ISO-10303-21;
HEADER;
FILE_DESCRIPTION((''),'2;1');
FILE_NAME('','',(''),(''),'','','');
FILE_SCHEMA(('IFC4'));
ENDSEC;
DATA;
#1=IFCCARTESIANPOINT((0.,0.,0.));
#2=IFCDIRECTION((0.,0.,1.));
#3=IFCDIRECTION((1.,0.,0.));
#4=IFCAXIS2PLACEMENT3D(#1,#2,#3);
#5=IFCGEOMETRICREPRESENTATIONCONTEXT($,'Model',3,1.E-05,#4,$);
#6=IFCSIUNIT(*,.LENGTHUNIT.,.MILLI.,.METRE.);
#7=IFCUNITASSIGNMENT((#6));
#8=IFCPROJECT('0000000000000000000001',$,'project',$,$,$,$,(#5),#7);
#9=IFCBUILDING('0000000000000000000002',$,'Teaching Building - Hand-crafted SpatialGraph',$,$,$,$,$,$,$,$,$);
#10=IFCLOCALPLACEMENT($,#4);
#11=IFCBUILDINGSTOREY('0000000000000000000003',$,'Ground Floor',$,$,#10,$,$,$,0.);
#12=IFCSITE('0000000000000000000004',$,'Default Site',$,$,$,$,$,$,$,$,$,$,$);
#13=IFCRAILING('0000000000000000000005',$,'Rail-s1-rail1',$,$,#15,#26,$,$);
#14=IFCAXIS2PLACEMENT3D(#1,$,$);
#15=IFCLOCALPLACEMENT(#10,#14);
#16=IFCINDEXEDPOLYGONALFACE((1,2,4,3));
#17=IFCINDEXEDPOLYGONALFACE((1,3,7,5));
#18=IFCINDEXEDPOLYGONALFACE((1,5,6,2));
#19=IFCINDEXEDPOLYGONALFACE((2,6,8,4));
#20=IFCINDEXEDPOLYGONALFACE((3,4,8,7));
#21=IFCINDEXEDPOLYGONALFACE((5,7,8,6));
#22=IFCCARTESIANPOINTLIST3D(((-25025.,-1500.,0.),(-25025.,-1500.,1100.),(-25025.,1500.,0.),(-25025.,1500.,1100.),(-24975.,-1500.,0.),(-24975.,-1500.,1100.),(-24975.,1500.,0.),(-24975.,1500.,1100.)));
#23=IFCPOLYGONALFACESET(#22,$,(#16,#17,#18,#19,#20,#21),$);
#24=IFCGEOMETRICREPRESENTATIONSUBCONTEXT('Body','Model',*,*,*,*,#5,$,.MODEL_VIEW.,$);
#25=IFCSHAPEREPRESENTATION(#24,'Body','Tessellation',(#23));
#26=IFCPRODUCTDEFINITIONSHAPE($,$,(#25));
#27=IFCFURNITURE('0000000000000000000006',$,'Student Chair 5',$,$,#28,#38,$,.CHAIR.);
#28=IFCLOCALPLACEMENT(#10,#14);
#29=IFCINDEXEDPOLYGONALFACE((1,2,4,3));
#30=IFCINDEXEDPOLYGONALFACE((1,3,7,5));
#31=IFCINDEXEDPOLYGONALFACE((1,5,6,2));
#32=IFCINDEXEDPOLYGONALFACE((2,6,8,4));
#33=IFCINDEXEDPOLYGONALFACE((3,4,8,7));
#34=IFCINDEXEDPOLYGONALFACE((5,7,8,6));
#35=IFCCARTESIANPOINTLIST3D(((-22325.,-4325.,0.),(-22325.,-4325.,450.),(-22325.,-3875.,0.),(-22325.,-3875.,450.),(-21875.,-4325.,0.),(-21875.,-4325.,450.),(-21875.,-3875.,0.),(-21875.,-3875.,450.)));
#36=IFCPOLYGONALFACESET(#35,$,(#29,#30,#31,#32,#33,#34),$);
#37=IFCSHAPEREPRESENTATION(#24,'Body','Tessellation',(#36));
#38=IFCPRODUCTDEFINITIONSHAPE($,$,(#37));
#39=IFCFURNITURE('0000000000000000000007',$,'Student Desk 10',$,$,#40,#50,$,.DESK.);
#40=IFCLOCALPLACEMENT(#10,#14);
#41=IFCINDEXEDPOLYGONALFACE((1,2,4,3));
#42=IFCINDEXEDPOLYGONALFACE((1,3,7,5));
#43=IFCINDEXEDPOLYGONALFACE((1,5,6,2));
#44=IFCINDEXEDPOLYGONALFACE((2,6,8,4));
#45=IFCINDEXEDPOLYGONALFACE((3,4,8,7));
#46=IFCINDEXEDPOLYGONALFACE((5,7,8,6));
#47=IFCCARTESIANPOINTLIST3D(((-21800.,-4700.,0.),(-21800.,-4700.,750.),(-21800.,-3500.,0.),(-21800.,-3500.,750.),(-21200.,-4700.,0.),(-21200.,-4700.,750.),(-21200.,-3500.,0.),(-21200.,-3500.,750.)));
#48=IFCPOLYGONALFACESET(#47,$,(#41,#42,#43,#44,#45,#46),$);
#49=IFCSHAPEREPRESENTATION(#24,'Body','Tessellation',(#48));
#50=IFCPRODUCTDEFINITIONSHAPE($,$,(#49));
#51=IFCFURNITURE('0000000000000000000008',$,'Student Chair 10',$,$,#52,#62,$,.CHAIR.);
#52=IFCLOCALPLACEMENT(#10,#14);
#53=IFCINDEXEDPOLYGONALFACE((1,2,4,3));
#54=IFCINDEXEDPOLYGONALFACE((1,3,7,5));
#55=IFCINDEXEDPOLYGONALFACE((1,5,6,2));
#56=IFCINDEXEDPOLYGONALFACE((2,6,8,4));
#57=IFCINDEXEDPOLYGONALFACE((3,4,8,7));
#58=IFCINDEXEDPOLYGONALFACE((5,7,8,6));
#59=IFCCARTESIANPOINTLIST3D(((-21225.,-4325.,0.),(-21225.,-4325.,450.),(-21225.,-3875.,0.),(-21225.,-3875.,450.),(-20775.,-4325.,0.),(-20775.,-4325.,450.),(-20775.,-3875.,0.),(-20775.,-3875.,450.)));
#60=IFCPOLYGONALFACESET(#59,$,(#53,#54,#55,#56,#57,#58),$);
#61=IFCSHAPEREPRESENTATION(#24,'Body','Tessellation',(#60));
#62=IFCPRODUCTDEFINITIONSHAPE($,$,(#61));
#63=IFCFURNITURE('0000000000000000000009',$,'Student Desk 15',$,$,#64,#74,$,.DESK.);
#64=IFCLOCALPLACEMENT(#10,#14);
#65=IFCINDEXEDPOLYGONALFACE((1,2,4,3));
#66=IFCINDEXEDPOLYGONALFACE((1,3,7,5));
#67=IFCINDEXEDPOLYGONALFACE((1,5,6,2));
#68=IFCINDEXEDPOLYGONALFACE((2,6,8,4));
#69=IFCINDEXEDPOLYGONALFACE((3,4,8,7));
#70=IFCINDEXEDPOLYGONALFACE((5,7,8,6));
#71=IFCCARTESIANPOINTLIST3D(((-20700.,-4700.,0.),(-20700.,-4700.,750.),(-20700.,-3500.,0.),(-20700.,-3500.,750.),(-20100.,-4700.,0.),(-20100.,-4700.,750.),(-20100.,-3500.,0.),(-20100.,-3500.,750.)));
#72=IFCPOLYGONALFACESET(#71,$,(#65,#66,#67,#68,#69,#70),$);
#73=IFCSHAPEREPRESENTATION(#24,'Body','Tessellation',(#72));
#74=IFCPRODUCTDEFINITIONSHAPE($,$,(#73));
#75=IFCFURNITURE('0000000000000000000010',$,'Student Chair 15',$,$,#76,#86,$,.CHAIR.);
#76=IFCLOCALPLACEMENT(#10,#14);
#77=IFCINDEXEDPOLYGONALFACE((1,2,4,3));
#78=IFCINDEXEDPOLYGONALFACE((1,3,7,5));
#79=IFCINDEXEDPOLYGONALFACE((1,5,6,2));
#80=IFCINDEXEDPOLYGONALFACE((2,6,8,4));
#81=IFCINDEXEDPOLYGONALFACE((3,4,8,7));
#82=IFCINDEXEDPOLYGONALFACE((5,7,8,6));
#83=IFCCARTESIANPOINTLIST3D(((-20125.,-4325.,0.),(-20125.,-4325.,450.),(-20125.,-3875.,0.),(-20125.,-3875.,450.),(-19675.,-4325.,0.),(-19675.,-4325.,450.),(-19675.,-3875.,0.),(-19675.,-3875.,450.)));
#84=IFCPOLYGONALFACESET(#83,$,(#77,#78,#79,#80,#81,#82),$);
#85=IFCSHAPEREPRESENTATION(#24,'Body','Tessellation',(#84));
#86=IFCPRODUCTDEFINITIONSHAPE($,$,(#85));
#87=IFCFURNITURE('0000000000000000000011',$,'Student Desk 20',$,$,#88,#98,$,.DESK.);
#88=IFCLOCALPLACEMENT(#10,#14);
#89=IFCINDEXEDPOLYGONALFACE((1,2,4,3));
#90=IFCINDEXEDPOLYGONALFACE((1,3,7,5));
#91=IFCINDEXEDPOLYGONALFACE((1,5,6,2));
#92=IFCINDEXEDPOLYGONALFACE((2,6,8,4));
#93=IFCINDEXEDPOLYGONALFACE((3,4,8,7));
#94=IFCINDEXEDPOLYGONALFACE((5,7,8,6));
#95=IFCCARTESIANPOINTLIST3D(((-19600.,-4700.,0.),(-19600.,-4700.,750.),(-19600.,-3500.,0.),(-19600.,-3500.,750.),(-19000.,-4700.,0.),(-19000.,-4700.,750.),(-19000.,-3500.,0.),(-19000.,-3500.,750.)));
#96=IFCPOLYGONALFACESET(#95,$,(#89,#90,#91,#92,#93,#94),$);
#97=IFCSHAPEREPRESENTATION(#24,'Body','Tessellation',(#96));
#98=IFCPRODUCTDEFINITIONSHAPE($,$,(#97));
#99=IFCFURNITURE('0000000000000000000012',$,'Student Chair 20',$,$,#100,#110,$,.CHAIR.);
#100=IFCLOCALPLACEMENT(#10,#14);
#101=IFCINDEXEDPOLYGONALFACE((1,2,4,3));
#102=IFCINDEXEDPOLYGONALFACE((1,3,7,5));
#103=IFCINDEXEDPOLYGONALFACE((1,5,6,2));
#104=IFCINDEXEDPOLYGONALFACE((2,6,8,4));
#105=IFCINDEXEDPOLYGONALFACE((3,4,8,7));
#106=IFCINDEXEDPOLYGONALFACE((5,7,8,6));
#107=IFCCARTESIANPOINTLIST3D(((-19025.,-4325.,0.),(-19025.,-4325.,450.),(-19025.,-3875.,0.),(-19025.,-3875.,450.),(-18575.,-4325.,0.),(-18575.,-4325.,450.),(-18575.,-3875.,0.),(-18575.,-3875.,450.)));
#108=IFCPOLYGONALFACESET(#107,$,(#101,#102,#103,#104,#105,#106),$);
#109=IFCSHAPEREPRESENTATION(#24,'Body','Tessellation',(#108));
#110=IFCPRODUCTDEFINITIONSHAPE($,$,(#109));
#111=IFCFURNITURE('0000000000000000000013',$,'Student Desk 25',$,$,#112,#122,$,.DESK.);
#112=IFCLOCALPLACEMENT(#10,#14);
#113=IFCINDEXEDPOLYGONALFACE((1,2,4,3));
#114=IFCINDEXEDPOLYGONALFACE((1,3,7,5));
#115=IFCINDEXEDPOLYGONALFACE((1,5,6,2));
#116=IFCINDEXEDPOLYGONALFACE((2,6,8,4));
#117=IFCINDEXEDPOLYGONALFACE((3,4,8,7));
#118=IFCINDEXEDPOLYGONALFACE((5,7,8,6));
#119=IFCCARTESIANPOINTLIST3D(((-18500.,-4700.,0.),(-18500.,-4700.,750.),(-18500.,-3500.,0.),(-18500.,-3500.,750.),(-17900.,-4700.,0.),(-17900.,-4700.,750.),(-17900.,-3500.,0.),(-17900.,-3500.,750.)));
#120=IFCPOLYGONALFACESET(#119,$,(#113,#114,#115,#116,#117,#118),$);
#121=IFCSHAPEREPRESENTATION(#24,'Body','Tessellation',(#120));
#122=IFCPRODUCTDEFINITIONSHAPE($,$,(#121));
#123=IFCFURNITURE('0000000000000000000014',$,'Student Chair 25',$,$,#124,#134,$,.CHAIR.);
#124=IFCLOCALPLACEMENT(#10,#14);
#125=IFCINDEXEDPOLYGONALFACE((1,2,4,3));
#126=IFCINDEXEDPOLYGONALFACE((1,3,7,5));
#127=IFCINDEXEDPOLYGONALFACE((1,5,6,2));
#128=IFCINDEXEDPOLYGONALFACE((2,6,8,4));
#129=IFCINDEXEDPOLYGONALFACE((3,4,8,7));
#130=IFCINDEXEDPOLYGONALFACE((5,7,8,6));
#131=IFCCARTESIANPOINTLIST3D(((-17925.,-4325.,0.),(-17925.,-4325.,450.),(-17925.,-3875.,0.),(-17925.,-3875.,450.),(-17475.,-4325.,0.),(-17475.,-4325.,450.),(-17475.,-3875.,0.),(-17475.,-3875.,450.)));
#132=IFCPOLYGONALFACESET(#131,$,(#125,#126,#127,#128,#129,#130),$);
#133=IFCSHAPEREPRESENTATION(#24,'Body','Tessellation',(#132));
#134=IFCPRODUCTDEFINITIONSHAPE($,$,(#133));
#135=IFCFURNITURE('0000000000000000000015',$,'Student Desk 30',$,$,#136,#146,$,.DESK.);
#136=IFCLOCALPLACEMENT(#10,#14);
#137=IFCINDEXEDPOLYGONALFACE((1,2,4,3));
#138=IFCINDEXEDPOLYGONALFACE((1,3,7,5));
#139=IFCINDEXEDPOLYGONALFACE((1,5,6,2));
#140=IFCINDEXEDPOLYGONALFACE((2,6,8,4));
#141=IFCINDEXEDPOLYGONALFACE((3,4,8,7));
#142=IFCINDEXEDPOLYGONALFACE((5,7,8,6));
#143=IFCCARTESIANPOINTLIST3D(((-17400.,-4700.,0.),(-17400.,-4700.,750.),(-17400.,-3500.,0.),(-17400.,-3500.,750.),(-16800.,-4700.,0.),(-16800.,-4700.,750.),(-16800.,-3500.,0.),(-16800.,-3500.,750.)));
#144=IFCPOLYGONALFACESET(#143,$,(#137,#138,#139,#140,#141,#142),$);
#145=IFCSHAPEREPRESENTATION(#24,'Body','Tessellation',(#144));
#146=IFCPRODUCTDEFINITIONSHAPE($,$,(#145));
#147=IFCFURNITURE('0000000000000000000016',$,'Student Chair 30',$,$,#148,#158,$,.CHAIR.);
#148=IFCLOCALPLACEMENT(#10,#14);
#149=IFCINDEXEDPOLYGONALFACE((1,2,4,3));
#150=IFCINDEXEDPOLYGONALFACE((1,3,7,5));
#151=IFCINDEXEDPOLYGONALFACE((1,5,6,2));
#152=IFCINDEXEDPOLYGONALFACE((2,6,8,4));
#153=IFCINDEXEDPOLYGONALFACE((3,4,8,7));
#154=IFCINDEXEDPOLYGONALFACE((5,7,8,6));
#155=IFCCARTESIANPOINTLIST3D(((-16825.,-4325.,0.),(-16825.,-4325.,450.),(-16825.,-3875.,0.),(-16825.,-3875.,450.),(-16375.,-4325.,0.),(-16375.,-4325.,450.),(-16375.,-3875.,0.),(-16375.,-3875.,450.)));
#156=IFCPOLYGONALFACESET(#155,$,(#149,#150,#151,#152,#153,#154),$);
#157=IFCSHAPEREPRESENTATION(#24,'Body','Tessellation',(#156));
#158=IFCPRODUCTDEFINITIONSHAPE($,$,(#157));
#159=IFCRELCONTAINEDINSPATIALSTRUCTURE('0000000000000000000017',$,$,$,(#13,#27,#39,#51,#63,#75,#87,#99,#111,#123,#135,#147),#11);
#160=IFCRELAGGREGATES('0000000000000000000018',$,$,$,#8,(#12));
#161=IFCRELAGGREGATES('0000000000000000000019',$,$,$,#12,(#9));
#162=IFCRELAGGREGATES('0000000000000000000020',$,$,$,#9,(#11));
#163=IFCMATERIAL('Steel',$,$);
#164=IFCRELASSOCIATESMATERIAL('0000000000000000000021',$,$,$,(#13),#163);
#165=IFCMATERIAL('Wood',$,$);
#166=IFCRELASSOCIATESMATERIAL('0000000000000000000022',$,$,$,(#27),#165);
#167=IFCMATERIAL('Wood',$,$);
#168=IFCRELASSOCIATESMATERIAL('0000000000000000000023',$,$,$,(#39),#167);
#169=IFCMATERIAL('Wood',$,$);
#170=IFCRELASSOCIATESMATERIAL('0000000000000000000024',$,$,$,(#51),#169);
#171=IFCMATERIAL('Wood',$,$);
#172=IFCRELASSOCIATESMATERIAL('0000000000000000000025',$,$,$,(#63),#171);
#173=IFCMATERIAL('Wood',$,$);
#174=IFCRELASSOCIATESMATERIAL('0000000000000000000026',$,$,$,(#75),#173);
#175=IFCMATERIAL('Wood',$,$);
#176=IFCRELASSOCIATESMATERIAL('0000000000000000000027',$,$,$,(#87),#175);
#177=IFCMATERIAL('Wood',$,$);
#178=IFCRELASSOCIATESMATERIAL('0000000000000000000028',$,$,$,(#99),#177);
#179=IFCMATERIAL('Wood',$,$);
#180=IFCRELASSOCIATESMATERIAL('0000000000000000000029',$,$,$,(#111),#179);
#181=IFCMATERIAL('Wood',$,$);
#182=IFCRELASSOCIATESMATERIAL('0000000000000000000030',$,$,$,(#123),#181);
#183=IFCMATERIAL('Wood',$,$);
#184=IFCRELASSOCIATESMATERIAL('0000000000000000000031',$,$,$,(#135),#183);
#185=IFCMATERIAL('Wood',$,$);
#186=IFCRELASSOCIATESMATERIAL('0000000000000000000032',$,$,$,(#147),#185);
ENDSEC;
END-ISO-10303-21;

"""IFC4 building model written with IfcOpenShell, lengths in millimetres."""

from ifc_helpers import new_model, si_unit, frame, frame_2d, origin_with_axes, origin_2d, place, context, subcontext, project, spatial, rectangle, extrude, material, element, save


model = new_model("IFC4")

# Units and contexts
model_context = context("Model", 3, precision=1e-05, world=origin_with_axes())
body_context = subcontext(model_context, "Body", "Model", "MODEL_VIEW")
ifc_project = project(units=[si_unit("LENGTHUNIT", "METRE", prefix="MILLI")], contexts=[model_context])

# Site, building, storey
site = spatial("IfcSite", under=ifc_project, Name="Default Site")
building = spatial("IfcBuilding", under=site, Name="Teaching Building - Hand-crafted SpatialGraph")
storey_placement = place(None, origin_with_axes())
storey = spatial("IfcBuildingStorey", under=building, at=storey_placement, Name="Ground Floor", Elevation=0.0)

# Railing
ifc_material_1 = material(Name="Steel")
railing_placement = place(storey_placement, frame((-25000.0, -1500.0, 0.0), z_axis=(0.0, 0.0, 1.0), x_axis=(0.0, 1.0, 0.0)))
element("IfcRailing", 1, at=railing_placement, inside=storey, material=ifc_material_1, Name="Rail-s1-rail1", context=body_context, shape_type="SweptSolid", body=[
    extrude(rectangle(XDim=3000.0, YDim=50.0, at=frame_2d((1500.0, 0.0))), origin_with_axes(), (0.0, 0.0, 1.0), 1100.0),
])

# Furniture
ifc_material_2 = material(Name="Wood")
furniture_1_placement = place(storey_placement, frame((-22100.0, -4100.0, 0.0), z_axis=(0.0, 0.0, 1.0), x_axis=(1.0, 0.0, 0.0)))
element("IfcFurniture", 2, at=furniture_1_placement, inside=storey, material=ifc_material_2, Name="Student Chair 5", PredefinedType="CHAIR", context=body_context, shape_type="SweptSolid", body=[
    extrude(rectangle(XDim=450.0, YDim=450.0, at=origin_2d()), origin_with_axes(), (0.0, 0.0, 1.0), 450.0),
])
ifc_material_3 = material(Name="Wood")
furniture_2_placement = place(storey_placement, frame((-21500.0, -4100.0, 0.0), z_axis=(0.0, 0.0, 1.0), x_axis=(0.0, 1.0, 0.0)))
element("IfcFurniture", 3, at=furniture_2_placement, inside=storey, material=ifc_material_3, Name="Student Desk 10", PredefinedType="DESK", context=body_context, shape_type="SweptSolid", body=[
    extrude(rectangle(XDim=1200.0, YDim=600.0, at=origin_2d()), origin_with_axes(), (0.0, 0.0, 1.0), 750.0),
])
ifc_material_4 = material(Name="Wood")
furniture_3_placement = place(storey_placement, frame((-21000.0, -4100.0, 0.0), z_axis=(0.0, 0.0, 1.0), x_axis=(1.0, 0.0, 0.0)))
element("IfcFurniture", 4, at=furniture_3_placement, inside=storey, material=ifc_material_4, Name="Student Chair 10", PredefinedType="CHAIR", context=body_context, shape_type="SweptSolid", body=[
    extrude(rectangle(XDim=450.0, YDim=450.0, at=origin_2d()), origin_with_axes(), (0.0, 0.0, 1.0), 450.0),
])
ifc_material_5 = material(Name="Wood")
furniture_4_placement = place(storey_placement, frame((-20400.0, -4100.0, 0.0), z_axis=(0.0, 0.0, 1.0), x_axis=(0.0, 1.0, 0.0)))
element("IfcFurniture", 5, at=furniture_4_placement, inside=storey, material=ifc_material_5, Name="Student Desk 15", PredefinedType="DESK", context=body_context, shape_type="SweptSolid", body=[
    extrude(rectangle(XDim=1200.0, YDim=600.0, at=origin_2d()), origin_with_axes(), (0.0, 0.0, 1.0), 750.0),
])
ifc_material_6 = material(Name="Wood")
furniture_5_placement = place(storey_placement, frame((-19900.0, -4100.0, 0.0), z_axis=(0.0, 0.0, 1.0), x_axis=(1.0, 0.0, 0.0)))
element("IfcFurniture", 6, at=furniture_5_placement, inside=storey, material=ifc_material_6, Name="Student Chair 15", PredefinedType="CHAIR", context=body_context, shape_type="SweptSolid", body=[
    extrude(rectangle(XDim=450.0, YDim=450.0, at=origin_2d()), origin_with_axes(), (0.0, 0.0, 1.0), 450.0),
])
ifc_material_7 = material(Name="Wood")
furniture_6_placement = place(storey_placement, frame((-19300.0, -4100.0, 0.0), z_axis=(0.0, 0.0, 1.0), x_axis=(0.0, 1.0, 0.0)))
element("IfcFurniture", 7, at=furniture_6_placement, inside=storey, material=ifc_material_7, Name="Student Desk 20", PredefinedType="DESK", context=body_context, shape_type="SweptSolid", body=[
    extrude(rectangle(XDim=1200.0, YDim=600.0, at=origin_2d()), origin_with_axes(), (0.0, 0.0, 1.0), 750.0),
])
ifc_material_8 = material(Name="Wood")
furniture_7_placement = place(storey_placement, frame((-18800.0, -4100.0, 0.0), z_axis=(0.0, 0.0, 1.0), x_axis=(1.0, 0.0, 0.0)))
element("IfcFurniture", 8, at=furniture_7_placement, inside=storey, material=ifc_material_8, Name="Student Chair 20", PredefinedType="CHAIR", context=body_context, shape_type="SweptSolid", body=[
    extrude(rectangle(XDim=450.0, YDim=450.0, at=origin_2d()), origin_with_axes(), (0.0, 0.0, 1.0), 450.0),
])
ifc_material_9 = material(Name="Wood")
furniture_8_placement = place(storey_placement, frame((-18200.0, -4100.0, 0.0), z_axis=(0.0, 0.0, 1.0), x_axis=(0.0, 1.0, 0.0)))
element("IfcFurniture", 9, at=furniture_8_placement, inside=storey, material=ifc_material_9, Name="Student Desk 25", PredefinedType="DESK", context=body_context, shape_type="SweptSolid", body=[
    extrude(rectangle(XDim=1200.0, YDim=600.0, at=origin_2d()), origin_with_axes(), (0.0, 0.0, 1.0), 750.0),
])
ifc_material_10 = material(Name="Wood")
furniture_9_placement = place(storey_placement, frame((-17700.0, -4100.0, 0.0), z_axis=(0.0, 0.0, 1.0), x_axis=(1.0, 0.0, 0.0)))
element("IfcFurniture", 10, at=furniture_9_placement, inside=storey, material=ifc_material_10, Name="Student Chair 25", PredefinedType="CHAIR", context=body_context, shape_type="SweptSolid", body=[
    extrude(rectangle(XDim=450.0, YDim=450.0, at=origin_2d()), origin_with_axes(), (0.0, 0.0, 1.0), 450.0),
])
ifc_material_11 = material(Name="Wood")
furniture_10_placement = place(storey_placement, frame((-17100.0, -4100.0, 0.0), z_axis=(0.0, 0.0, 1.0), x_axis=(0.0, 1.0, 0.0)))
element("IfcFurniture", 11, at=furniture_10_placement, inside=storey, material=ifc_material_11, Name="Student Desk 30", PredefinedType="DESK", context=body_context, shape_type="SweptSolid", body=[
    extrude(rectangle(XDim=1200.0, YDim=600.0, at=origin_2d()), origin_with_axes(), (0.0, 0.0, 1.0), 750.0),
])
ifc_material_12 = material(Name="Wood")
furniture_11_placement = place(storey_placement, frame((-16600.0, -4100.0, 0.0), z_axis=(0.0, 0.0, 1.0), x_axis=(1.0, 0.0, 0.0)))
element("IfcFurniture", 12, at=furniture_11_placement, inside=storey, material=ifc_material_12, Name="Student Chair 30", PredefinedType="CHAIR", context=body_context, shape_type="SweptSolid", body=[
    extrude(rectangle(XDim=450.0, YDim=450.0, at=origin_2d()), origin_with_axes(), (0.0, 0.0, 1.0), 450.0),
])

save(model, "model.ifc")
